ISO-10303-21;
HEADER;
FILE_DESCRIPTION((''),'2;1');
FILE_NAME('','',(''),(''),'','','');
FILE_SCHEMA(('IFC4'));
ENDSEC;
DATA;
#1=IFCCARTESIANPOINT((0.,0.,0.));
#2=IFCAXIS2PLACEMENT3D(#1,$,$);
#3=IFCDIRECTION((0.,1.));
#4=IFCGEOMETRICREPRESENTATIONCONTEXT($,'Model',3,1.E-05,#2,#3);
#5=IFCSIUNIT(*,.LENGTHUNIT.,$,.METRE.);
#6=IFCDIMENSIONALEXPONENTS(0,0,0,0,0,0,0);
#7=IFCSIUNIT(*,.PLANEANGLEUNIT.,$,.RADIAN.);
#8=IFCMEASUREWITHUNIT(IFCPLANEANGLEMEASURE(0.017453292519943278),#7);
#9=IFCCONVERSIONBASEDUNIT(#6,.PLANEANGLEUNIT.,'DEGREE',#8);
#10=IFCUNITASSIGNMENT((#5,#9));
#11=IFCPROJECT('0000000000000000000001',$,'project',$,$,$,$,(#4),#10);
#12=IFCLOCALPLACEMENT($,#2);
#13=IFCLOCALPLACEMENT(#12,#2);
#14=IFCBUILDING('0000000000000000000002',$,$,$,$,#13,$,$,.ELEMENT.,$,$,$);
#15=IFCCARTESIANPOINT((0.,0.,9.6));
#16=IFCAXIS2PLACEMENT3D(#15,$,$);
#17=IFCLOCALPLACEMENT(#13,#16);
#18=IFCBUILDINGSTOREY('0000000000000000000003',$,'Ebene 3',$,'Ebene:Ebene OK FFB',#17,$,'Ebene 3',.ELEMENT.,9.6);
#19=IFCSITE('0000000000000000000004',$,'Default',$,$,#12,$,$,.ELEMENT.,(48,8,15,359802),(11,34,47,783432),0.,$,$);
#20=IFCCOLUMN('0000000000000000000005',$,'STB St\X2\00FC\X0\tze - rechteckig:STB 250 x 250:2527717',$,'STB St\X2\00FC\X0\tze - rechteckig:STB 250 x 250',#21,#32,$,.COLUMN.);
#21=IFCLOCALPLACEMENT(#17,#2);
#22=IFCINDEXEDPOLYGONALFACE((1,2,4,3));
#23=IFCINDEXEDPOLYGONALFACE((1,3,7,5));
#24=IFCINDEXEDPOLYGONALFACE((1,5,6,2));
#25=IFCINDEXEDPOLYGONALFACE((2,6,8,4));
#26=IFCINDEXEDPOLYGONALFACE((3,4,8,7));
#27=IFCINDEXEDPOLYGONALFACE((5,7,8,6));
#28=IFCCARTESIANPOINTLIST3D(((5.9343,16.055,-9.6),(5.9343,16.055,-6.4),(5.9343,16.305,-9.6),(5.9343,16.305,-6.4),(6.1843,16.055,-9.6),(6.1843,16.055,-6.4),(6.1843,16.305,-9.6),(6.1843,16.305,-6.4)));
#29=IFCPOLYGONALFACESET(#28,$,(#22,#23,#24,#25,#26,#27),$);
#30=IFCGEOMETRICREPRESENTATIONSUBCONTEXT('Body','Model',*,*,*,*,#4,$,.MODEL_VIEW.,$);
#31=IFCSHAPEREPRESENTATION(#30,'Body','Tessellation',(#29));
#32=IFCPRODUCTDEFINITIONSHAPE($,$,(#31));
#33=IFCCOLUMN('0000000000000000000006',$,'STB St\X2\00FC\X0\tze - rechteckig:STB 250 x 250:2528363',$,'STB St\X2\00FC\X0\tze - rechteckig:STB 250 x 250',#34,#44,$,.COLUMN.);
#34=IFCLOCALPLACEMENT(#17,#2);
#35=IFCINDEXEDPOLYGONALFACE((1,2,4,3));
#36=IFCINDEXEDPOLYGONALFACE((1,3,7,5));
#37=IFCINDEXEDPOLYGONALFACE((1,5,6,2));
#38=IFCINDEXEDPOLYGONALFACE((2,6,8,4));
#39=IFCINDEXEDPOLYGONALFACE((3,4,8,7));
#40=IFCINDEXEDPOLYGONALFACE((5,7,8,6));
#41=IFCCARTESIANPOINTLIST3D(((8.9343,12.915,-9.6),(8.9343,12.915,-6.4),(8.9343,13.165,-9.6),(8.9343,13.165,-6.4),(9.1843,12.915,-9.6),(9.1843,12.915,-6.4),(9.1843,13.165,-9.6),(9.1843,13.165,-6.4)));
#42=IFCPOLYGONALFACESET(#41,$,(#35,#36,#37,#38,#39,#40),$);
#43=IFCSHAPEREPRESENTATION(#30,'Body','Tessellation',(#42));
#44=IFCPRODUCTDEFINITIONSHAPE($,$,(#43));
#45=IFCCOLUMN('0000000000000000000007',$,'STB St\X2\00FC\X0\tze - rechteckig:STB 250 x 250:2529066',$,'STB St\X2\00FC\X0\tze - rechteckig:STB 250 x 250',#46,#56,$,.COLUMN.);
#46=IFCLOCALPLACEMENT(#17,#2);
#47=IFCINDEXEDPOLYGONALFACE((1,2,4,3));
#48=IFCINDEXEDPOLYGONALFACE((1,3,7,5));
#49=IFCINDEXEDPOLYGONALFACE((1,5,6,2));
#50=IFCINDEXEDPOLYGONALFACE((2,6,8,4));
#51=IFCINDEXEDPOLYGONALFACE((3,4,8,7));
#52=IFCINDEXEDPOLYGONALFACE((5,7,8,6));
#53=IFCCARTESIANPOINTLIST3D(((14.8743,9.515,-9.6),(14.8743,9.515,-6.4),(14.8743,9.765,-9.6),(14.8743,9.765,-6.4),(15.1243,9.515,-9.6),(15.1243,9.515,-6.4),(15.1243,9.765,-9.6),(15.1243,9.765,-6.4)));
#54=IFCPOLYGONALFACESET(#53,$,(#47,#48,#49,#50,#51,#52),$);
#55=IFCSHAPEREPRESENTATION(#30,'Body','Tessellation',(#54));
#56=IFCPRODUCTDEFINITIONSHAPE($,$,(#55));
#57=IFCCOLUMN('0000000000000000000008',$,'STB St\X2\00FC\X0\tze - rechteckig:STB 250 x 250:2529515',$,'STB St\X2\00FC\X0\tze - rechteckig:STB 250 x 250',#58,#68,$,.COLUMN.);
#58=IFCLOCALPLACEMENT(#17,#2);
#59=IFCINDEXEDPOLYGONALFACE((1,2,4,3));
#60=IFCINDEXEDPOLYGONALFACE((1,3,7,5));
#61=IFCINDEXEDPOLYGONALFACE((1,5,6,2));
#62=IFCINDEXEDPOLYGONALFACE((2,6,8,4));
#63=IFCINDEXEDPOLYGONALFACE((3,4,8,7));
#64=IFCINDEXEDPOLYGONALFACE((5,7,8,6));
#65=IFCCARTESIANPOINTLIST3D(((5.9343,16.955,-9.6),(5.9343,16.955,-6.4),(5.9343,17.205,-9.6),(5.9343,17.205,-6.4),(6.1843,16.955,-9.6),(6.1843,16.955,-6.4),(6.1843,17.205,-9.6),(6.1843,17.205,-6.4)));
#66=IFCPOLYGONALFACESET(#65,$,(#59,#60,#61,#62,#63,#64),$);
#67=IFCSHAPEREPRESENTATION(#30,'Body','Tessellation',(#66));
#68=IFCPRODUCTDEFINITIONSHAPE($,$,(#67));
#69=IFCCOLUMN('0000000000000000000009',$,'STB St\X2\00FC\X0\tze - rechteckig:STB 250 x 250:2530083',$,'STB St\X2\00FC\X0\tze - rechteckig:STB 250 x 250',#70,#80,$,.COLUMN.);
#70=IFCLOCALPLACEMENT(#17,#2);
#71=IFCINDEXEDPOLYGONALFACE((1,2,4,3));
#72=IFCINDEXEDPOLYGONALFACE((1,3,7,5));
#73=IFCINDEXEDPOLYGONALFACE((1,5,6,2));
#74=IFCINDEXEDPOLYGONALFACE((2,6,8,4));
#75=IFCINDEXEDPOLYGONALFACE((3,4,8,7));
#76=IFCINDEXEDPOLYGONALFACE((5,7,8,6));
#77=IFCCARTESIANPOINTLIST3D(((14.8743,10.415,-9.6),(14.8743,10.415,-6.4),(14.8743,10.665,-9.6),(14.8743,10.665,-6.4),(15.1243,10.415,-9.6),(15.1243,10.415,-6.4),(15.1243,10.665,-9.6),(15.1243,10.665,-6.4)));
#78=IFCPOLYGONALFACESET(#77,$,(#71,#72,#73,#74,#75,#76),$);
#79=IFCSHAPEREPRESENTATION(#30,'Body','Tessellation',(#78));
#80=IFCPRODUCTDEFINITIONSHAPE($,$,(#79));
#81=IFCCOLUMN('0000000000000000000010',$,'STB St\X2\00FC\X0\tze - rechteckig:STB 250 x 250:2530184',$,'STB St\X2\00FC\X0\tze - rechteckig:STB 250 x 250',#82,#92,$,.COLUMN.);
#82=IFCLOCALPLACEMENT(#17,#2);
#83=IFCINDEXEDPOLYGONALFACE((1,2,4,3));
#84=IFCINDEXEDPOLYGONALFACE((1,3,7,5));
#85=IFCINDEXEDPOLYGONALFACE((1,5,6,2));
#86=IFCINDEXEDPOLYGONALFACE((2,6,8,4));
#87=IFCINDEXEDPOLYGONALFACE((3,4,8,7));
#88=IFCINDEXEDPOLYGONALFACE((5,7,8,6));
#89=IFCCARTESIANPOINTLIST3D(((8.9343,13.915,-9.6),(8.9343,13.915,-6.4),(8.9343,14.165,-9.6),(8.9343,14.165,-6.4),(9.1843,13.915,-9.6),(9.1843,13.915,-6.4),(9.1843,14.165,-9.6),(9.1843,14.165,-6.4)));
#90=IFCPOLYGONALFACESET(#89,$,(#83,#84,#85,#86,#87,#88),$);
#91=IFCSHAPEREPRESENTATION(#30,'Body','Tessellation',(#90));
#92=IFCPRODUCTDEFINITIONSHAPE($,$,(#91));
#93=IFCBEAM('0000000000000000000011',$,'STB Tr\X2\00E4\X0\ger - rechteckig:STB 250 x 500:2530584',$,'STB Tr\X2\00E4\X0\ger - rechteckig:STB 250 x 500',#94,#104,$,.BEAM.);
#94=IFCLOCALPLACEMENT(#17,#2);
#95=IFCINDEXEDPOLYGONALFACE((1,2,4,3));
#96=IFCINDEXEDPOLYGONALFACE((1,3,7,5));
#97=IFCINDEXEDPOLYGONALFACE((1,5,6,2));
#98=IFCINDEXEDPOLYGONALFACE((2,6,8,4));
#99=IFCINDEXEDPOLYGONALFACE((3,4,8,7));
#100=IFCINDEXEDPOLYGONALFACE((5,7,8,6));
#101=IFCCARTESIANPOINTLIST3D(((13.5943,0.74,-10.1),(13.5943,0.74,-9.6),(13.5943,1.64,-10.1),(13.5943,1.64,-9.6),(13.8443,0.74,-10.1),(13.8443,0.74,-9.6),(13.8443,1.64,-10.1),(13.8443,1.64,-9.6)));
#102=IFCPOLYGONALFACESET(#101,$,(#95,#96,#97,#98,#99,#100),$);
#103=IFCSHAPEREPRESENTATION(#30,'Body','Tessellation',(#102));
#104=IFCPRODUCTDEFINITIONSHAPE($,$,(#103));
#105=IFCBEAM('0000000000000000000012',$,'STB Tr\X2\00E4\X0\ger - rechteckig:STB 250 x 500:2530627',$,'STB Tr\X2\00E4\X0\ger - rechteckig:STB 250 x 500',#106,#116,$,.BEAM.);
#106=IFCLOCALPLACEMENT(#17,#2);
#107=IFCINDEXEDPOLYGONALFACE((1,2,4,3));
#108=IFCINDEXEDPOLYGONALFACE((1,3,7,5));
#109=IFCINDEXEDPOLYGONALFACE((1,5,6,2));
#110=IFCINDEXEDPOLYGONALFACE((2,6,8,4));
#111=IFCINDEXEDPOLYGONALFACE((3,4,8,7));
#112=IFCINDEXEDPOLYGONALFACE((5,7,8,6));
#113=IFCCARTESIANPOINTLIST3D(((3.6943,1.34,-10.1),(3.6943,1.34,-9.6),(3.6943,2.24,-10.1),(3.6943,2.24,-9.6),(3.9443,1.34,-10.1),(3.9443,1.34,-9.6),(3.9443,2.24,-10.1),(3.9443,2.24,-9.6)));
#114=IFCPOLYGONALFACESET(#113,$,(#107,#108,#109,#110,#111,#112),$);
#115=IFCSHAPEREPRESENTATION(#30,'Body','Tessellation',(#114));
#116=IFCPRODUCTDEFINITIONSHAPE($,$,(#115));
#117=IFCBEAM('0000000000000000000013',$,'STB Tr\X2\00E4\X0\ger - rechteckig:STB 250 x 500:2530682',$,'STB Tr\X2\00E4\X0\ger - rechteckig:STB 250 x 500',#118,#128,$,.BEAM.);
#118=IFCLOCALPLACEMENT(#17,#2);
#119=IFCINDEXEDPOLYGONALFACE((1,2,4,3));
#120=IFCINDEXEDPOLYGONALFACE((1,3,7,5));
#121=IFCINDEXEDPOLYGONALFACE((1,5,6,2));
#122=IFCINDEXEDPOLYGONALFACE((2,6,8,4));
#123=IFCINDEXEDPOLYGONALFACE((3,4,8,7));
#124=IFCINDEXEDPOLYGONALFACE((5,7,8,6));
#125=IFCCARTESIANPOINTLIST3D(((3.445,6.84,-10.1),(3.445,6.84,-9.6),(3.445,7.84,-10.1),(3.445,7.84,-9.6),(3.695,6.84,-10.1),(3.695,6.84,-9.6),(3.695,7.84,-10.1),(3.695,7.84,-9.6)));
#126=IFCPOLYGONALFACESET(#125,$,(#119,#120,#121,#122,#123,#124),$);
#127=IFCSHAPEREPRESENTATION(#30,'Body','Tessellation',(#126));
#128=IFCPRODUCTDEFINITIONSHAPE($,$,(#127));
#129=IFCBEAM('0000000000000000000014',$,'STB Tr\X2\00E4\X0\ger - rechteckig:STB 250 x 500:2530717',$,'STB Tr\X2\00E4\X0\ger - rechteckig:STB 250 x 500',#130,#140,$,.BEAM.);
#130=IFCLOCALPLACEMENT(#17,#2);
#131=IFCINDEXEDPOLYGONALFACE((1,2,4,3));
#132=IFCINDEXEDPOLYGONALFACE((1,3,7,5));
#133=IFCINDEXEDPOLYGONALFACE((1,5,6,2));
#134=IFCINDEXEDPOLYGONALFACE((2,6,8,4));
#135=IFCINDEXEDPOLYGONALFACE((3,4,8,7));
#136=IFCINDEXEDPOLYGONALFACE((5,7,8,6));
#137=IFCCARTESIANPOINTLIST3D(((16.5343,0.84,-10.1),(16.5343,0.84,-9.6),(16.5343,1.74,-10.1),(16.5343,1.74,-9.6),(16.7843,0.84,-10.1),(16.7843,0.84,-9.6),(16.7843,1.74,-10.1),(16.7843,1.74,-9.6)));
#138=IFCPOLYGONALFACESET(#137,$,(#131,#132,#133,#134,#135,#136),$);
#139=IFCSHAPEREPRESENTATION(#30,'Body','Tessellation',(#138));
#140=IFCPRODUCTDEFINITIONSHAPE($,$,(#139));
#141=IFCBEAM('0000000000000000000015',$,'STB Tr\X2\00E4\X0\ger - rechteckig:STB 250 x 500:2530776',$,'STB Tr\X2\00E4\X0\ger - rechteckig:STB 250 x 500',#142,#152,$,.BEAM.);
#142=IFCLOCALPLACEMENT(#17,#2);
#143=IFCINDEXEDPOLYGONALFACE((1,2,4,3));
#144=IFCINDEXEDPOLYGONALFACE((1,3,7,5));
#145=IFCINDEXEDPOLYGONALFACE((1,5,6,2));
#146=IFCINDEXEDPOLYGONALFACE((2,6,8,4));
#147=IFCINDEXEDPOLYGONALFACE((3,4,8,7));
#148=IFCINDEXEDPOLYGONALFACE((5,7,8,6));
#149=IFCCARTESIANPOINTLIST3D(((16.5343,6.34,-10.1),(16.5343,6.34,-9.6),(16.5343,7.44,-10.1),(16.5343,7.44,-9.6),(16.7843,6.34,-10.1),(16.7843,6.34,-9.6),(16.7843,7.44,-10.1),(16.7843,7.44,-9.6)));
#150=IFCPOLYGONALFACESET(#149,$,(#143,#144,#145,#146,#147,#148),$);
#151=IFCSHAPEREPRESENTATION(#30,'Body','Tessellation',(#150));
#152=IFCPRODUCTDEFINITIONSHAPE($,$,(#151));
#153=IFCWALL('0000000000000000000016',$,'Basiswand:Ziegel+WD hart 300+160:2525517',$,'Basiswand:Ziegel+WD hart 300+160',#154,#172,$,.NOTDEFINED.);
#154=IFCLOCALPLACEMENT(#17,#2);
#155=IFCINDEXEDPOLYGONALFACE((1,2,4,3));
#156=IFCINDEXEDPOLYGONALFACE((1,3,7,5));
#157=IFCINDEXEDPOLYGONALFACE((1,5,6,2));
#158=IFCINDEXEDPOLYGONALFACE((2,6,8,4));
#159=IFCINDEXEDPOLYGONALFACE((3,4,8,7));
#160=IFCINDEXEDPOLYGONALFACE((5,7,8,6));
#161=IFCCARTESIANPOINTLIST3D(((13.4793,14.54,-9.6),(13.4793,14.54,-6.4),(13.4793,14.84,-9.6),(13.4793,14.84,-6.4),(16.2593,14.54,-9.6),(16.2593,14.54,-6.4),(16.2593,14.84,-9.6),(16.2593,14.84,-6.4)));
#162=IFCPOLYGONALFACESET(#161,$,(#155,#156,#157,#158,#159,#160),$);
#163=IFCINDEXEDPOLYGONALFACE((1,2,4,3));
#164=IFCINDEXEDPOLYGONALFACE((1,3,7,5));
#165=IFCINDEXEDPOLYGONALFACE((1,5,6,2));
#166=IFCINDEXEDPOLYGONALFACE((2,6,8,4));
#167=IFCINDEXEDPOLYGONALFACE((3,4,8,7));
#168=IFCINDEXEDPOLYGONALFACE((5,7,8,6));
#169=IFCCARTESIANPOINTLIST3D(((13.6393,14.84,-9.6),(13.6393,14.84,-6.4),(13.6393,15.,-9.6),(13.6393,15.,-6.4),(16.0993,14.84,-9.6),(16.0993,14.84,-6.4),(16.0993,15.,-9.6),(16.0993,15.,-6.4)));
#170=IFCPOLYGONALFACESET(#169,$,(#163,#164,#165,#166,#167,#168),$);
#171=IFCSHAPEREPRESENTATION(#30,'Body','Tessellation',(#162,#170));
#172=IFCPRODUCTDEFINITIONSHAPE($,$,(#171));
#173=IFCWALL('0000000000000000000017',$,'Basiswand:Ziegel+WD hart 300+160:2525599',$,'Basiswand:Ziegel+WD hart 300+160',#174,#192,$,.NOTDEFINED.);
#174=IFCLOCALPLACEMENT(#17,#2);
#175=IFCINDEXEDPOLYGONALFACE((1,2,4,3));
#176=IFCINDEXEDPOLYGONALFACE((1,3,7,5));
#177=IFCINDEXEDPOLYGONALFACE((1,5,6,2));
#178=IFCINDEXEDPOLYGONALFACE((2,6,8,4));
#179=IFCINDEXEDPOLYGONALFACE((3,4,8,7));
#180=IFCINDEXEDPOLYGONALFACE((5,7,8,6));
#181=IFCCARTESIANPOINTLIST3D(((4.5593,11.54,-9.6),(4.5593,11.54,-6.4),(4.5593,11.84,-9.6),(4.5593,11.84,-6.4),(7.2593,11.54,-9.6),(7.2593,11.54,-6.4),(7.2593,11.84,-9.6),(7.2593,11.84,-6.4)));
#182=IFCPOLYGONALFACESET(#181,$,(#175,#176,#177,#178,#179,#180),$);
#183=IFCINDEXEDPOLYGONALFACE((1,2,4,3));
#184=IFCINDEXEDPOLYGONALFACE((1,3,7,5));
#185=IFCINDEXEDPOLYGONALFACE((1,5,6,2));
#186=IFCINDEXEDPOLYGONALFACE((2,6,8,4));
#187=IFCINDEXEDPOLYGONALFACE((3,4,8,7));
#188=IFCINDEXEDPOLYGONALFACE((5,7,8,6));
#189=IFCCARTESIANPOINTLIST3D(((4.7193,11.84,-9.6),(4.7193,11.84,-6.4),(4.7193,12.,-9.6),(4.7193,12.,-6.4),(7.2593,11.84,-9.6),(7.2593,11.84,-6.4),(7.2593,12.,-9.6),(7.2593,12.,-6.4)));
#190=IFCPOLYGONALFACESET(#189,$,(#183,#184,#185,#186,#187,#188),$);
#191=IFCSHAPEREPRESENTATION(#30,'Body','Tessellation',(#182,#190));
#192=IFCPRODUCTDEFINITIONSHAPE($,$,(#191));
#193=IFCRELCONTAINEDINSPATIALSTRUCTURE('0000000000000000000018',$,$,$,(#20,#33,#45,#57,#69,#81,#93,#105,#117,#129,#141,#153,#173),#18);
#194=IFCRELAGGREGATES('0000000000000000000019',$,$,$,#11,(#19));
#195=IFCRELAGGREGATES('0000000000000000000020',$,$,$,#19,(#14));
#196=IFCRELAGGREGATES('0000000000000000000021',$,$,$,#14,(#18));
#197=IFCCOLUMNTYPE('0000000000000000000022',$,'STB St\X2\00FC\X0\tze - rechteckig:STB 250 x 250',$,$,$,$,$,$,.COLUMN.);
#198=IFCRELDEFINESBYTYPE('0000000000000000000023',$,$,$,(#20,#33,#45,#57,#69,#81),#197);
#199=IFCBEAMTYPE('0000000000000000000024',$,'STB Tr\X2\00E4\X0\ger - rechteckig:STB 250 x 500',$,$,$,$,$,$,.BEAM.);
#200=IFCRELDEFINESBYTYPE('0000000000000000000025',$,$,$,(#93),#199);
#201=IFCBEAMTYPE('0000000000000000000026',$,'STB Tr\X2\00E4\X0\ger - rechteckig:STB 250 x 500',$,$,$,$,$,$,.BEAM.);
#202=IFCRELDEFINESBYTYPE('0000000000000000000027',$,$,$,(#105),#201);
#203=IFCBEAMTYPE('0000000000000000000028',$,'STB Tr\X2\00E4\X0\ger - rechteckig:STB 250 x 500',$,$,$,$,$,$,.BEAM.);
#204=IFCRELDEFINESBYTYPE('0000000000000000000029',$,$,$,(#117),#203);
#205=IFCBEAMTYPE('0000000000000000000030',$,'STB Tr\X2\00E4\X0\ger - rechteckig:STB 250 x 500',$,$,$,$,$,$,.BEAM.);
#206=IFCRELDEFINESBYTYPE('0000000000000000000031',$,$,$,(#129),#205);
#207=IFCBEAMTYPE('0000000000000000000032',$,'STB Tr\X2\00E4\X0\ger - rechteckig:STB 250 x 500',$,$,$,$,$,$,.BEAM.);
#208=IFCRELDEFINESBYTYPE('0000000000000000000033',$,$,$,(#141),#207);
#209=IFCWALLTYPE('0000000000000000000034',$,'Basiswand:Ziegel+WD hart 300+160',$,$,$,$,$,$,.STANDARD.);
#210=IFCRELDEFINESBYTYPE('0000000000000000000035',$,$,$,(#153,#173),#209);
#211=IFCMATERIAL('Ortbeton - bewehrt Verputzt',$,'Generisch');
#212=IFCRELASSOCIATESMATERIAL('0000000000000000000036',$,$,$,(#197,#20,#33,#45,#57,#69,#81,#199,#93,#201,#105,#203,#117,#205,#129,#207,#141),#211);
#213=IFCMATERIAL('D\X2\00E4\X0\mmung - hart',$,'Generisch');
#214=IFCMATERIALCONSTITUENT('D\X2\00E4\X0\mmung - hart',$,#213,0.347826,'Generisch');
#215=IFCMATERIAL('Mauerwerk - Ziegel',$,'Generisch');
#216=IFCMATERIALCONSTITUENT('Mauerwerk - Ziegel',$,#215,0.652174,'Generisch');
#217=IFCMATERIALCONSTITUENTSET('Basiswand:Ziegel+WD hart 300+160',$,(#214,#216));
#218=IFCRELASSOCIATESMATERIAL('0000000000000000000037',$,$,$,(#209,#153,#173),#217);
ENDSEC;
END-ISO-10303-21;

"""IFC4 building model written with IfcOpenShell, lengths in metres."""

from ifc_helpers import new_model, entity, si_unit, converted_unit, direction, frame, origin, place, context, subcontext, project, spatial, indexed_curve, outline, extrude, source, transform, mapped, material, constituent, constituent_set, type_object, type_shapes, element, save


model = new_model("IFC4")

# Units and contexts
model_context = context("Model", 3, precision=1e-05, world=origin(), true_north=direction((0.0, 1.0)))
body_context = subcontext(model_context, "Body", "Model", "MODEL_VIEW")
ifc_project = project(units=[si_unit("LENGTHUNIT", "METRE"), converted_unit("PLANEANGLEUNIT", "DEGREE", entity("IfcPlaneAngleMeasure", 0.017453292519943278), si_unit("PLANEANGLEUNIT", "RADIAN"), dimensions=[0, 0, 0, 0, 0, 0, 0])], contexts=[model_context])

# Site, building, storey
site_placement = place(None, origin())
site = spatial("IfcSite", under=ifc_project, at=site_placement, Name="Default", CompositionType="ELEMENT", RefLatitude=(48, 8, 15, 359802), RefLongitude=(11, 34, 47, 783432), RefElevation=0.0)
building_placement = place(site_placement, origin())
building = spatial("IfcBuilding", under=site, at=building_placement, CompositionType="ELEMENT")
storey_placement = place(building_placement, frame((0.0, 0.0, 9.6)))
storey = spatial("IfcBuildingStorey", under=building, at=storey_placement, Name="Ebene 3", ObjectType="Ebene:Ebene OK FFB", LongName="Ebene 3", CompositionType="ELEMENT", Elevation=9.6)

# Columns
ifc_material_1 = material(Name="Ortbeton - bewehrt Verputzt", Category="Generisch")
column_type = type_object("IfcColumnType", Name="STB Stütze - rechteckig:STB 250 x 250", PredefinedType="COLUMN", material=ifc_material_1)
shared_shape_1 = source(origin(), body_context, "Body", "SweptSolid", [
    extrude(outline(indexed_curve([(-0.125, -0.125), (0.125, -0.125), (0.125, 0.125), (-0.125, 0.125), (-0.125, -0.125)], self_intersect=False)), frame((0.0, 0.0, 0.0), z_axis=(0.0, 0.0, 1.0), x_axis=(-1.0, 0.0, 0.0)), (0.0, 0.0, 1.0), 3.2),
])
type_shapes(column_type, [shared_shape_1])
for number, where, name in (
    (1, (6.0593, 16.18, -9.6), "STB Stütze - rechteckig:STB 250 x 250:2527717"),
    (2, (9.0593, 13.04, -9.6), "STB Stütze - rechteckig:STB 250 x 250:2528363"),
    (3, (14.9993, 9.64, -9.6), "STB Stütze - rechteckig:STB 250 x 250:2529066"),
    (4, (6.0593, 17.08, -9.6), "STB Stütze - rechteckig:STB 250 x 250:2529515"),
    (5, (14.9993, 10.54, -9.6), "STB Stütze - rechteckig:STB 250 x 250:2530083"),
    (6, (9.0593, 14.04, -9.6), "STB Stütze - rechteckig:STB 250 x 250:2530184"),
):
    element("IfcColumn", number, at=place(storey_placement, frame(where)), inside=storey, type_object=column_type, material=ifc_material_1, Name=name, ObjectType="STB Stütze - rechteckig:STB 250 x 250", PredefinedType="COLUMN", context=body_context, shape_type="MappedRepresentation", body=[
        mapped(shared_shape_1, transform((0.0, 0.0, 0.0), scale=1.0)),
    ])

# Beams
beam_type_1 = type_object("IfcBeamType", Name="STB Träger - rechteckig:STB 250 x 500", PredefinedType="BEAM", material=ifc_material_1)
shared_shape_2 = source(origin(), body_context, "Body", "SweptSolid", [
    extrude(outline(indexed_curve([(-0.125, -0.25), (0.125, -0.25), (0.125, 0.25), (-0.125, 0.25), (-0.125, -0.25)], self_intersect=False)), frame((13.7193, 1.64, -0.25), z_axis=(0.0, -1.0, 0.0), x_axis=(-1.0, 0.0, 0.0)), (0.0, 0.0, 1.0), 0.9),
])
type_shapes(beam_type_1, [shared_shape_2])
beam_1_placement = place(storey_placement, frame((0.0, 0.0, -9.6)))
element("IfcBeam", 7, at=beam_1_placement, inside=storey, type_object=beam_type_1, material=ifc_material_1, Name="STB Träger - rechteckig:STB 250 x 500:2530584", ObjectType="STB Träger - rechteckig:STB 250 x 500", PredefinedType="BEAM", context=body_context, shape_type="MappedRepresentation", body=[
    mapped(shared_shape_2, transform((0.0, 0.0, 0.0), scale=1.0)),
])
beam_type_2 = type_object("IfcBeamType", Name="STB Träger - rechteckig:STB 250 x 500", PredefinedType="BEAM", material=ifc_material_1)
shared_shape_3 = source(origin(), body_context, "Body", "SweptSolid", [
    extrude(outline(indexed_curve([(-0.125, -0.25), (0.125, -0.25), (0.125, 0.25), (-0.125, 0.25), (-0.125, -0.25)], self_intersect=False)), frame((3.8193, 2.24, -0.25), z_axis=(0.0, -1.0, 0.0), x_axis=(-1.0, 0.0, 0.0)), (0.0, 0.0, 1.0), 0.9),
])
type_shapes(beam_type_2, [shared_shape_3])
beam_2_placement = place(storey_placement, frame((0.0, 0.0, -9.6)))
element("IfcBeam", 8, at=beam_2_placement, inside=storey, type_object=beam_type_2, material=ifc_material_1, Name="STB Träger - rechteckig:STB 250 x 500:2530627", ObjectType="STB Träger - rechteckig:STB 250 x 500", PredefinedType="BEAM", context=body_context, shape_type="MappedRepresentation", body=[
    mapped(shared_shape_3, transform((0.0, 0.0, 0.0), scale=1.0)),
])
beam_type_3 = type_object("IfcBeamType", Name="STB Träger - rechteckig:STB 250 x 500", PredefinedType="BEAM", material=ifc_material_1)
shared_shape_4 = source(origin(), body_context, "Body", "SweptSolid", [
    extrude(outline(indexed_curve([(-0.125, -0.25), (0.125, -0.25), (0.125, 0.25), (-0.125, 0.25), (-0.125, -0.25)], self_intersect=False)), frame((3.57, 7.84, -0.25), z_axis=(0.0, -1.0, 0.0), x_axis=(-1.0, 0.0, 0.0)), (0.0, 0.0, 1.0), 1.0),
])
type_shapes(beam_type_3, [shared_shape_4])
beam_3_placement = place(storey_placement, frame((0.0, 0.0, -9.6)))
element("IfcBeam", 9, at=beam_3_placement, inside=storey, type_object=beam_type_3, material=ifc_material_1, Name="STB Träger - rechteckig:STB 250 x 500:2530682", ObjectType="STB Träger - rechteckig:STB 250 x 500", PredefinedType="BEAM", context=body_context, shape_type="MappedRepresentation", body=[
    mapped(shared_shape_4, transform((0.0, 0.0, 0.0), scale=1.0)),
])
beam_type_4 = type_object("IfcBeamType", Name="STB Träger - rechteckig:STB 250 x 500", PredefinedType="BEAM", material=ifc_material_1)
shared_shape_5 = source(origin(), body_context, "Body", "SweptSolid", [
    extrude(outline(indexed_curve([(-0.125, -0.25), (0.125, -0.25), (0.125, 0.25), (-0.125, 0.25), (-0.125, -0.25)], self_intersect=False)), frame((16.6593, 1.74, -0.25), z_axis=(0.0, -1.0, 0.0), x_axis=(-1.0, 0.0, 0.0)), (0.0, 0.0, 1.0), 0.9),
])
type_shapes(beam_type_4, [shared_shape_5])
beam_4_placement = place(storey_placement, frame((0.0, 0.0, -9.6)))
element("IfcBeam", 10, at=beam_4_placement, inside=storey, type_object=beam_type_4, material=ifc_material_1, Name="STB Träger - rechteckig:STB 250 x 500:2530717", ObjectType="STB Träger - rechteckig:STB 250 x 500", PredefinedType="BEAM", context=body_context, shape_type="MappedRepresentation", body=[
    mapped(shared_shape_5, transform((0.0, 0.0, 0.0), scale=1.0)),
])
beam_type_5 = type_object("IfcBeamType", Name="STB Träger - rechteckig:STB 250 x 500", PredefinedType="BEAM", material=ifc_material_1)
shared_shape_6 = source(origin(), body_context, "Body", "SweptSolid", [
    extrude(outline(indexed_curve([(-0.125, -0.25), (0.125, -0.25), (0.125, 0.25), (-0.125, 0.25), (-0.125, -0.25)], self_intersect=False)), frame((16.6593, 7.44, -0.25), z_axis=(0.0, -1.0, 0.0), x_axis=(-1.0, 0.0, 0.0)), (0.0, 0.0, 1.0), 1.1),
])
type_shapes(beam_type_5, [shared_shape_6])
beam_5_placement = place(storey_placement, frame((0.0, 0.0, -9.6)))
element("IfcBeam", 11, at=beam_5_placement, inside=storey, type_object=beam_type_5, material=ifc_material_1, Name="STB Träger - rechteckig:STB 250 x 500:2530776", ObjectType="STB Träger - rechteckig:STB 250 x 500", PredefinedType="BEAM", context=body_context, shape_type="MappedRepresentation", body=[
    mapped(shared_shape_6, transform((0.0, 0.0, 0.0), scale=1.0)),
])

# Shared definitions
ifc_material_2 = material(Name="Dämmung - hart", Category="Generisch")
ifc_constituent_1 = constituent(ifc_material_2, Name="Dämmung - hart", Category="Generisch", fraction=0.347826)
ifc_material_3 = material(Name="Mauerwerk - Ziegel", Category="Generisch")
ifc_constituent_2 = constituent(ifc_material_3, Name="Mauerwerk - Ziegel", Category="Generisch", fraction=0.652174)
ifc_constituent_set = constituent_set(constituents=[ifc_constituent_1, ifc_constituent_2], Name="Basiswand:Ziegel+WD hart 300+160")
wall_type = type_object("IfcWallType", Name="Basiswand:Ziegel+WD hart 300+160", PredefinedType="STANDARD", material=ifc_constituent_set)

# Walls
wall_1_placement = place(storey_placement, frame((13.6393, 14.77, -9.6)))
element("IfcWall", 12, at=wall_1_placement, inside=storey, type_object=wall_type, material=ifc_constituent_set, Name="Basiswand:Ziegel+WD hart 300+160:2525517", ObjectType="Basiswand:Ziegel+WD hart 300+160", PredefinedType="NOTDEFINED", context=body_context, shape_type="SweptSolid", body=[
    extrude(outline(indexed_curve([(-0.15, -1.39), (0.15, -1.39), (0.15, 1.39), (-0.15, 1.39), (-0.15, -1.39)], self_intersect=False)), frame((1.23, -0.08, 0.0), z_axis=(0.0, 0.0, 1.0), x_axis=(0.0, 1.0, 0.0)), (0.0, 0.0, 1.0), 3.2),
    extrude(outline(indexed_curve([(-0.08, -1.23), (0.08, -1.23), (0.08, 1.23), (-0.08, 1.23), (-0.08, -1.23)], self_intersect=False)), frame((1.23, 0.15, 0.0), z_axis=(0.0, 0.0, 1.0), x_axis=(0.0, -1.0, 0.0)), (0.0, 0.0, 1.0), 3.2),
])
wall_2_placement = place(storey_placement, frame((4.7193, 11.77, -9.6)))
element("IfcWall", 13, at=wall_2_placement, inside=storey, type_object=wall_type, material=ifc_constituent_set, Name="Basiswand:Ziegel+WD hart 300+160:2525599", ObjectType="Basiswand:Ziegel+WD hart 300+160", PredefinedType="NOTDEFINED", context=body_context, shape_type="SweptSolid", body=[
    extrude(outline(indexed_curve([(-0.15, -1.35), (0.15, -1.35), (0.15, 1.35), (-0.15, 1.35), (-0.15, -1.35)], self_intersect=False)), frame((1.19, -0.08, 0.0), z_axis=(0.0, 0.0, 1.0), x_axis=(0.0, 1.0, 0.0)), (0.0, 0.0, 1.0), 3.2),
    extrude(outline(indexed_curve([(-0.08, -1.27), (0.08, -1.27), (0.08, 1.27), (-0.08, 1.27), (-0.08, -1.27)], self_intersect=False)), frame((1.27, 0.15, 0.0), z_axis=(0.0, 0.0, 1.0), x_axis=(0.0, -1.0, 0.0)), (0.0, 0.0, 1.0), 3.2),
])

save(model, "model.ifc")
